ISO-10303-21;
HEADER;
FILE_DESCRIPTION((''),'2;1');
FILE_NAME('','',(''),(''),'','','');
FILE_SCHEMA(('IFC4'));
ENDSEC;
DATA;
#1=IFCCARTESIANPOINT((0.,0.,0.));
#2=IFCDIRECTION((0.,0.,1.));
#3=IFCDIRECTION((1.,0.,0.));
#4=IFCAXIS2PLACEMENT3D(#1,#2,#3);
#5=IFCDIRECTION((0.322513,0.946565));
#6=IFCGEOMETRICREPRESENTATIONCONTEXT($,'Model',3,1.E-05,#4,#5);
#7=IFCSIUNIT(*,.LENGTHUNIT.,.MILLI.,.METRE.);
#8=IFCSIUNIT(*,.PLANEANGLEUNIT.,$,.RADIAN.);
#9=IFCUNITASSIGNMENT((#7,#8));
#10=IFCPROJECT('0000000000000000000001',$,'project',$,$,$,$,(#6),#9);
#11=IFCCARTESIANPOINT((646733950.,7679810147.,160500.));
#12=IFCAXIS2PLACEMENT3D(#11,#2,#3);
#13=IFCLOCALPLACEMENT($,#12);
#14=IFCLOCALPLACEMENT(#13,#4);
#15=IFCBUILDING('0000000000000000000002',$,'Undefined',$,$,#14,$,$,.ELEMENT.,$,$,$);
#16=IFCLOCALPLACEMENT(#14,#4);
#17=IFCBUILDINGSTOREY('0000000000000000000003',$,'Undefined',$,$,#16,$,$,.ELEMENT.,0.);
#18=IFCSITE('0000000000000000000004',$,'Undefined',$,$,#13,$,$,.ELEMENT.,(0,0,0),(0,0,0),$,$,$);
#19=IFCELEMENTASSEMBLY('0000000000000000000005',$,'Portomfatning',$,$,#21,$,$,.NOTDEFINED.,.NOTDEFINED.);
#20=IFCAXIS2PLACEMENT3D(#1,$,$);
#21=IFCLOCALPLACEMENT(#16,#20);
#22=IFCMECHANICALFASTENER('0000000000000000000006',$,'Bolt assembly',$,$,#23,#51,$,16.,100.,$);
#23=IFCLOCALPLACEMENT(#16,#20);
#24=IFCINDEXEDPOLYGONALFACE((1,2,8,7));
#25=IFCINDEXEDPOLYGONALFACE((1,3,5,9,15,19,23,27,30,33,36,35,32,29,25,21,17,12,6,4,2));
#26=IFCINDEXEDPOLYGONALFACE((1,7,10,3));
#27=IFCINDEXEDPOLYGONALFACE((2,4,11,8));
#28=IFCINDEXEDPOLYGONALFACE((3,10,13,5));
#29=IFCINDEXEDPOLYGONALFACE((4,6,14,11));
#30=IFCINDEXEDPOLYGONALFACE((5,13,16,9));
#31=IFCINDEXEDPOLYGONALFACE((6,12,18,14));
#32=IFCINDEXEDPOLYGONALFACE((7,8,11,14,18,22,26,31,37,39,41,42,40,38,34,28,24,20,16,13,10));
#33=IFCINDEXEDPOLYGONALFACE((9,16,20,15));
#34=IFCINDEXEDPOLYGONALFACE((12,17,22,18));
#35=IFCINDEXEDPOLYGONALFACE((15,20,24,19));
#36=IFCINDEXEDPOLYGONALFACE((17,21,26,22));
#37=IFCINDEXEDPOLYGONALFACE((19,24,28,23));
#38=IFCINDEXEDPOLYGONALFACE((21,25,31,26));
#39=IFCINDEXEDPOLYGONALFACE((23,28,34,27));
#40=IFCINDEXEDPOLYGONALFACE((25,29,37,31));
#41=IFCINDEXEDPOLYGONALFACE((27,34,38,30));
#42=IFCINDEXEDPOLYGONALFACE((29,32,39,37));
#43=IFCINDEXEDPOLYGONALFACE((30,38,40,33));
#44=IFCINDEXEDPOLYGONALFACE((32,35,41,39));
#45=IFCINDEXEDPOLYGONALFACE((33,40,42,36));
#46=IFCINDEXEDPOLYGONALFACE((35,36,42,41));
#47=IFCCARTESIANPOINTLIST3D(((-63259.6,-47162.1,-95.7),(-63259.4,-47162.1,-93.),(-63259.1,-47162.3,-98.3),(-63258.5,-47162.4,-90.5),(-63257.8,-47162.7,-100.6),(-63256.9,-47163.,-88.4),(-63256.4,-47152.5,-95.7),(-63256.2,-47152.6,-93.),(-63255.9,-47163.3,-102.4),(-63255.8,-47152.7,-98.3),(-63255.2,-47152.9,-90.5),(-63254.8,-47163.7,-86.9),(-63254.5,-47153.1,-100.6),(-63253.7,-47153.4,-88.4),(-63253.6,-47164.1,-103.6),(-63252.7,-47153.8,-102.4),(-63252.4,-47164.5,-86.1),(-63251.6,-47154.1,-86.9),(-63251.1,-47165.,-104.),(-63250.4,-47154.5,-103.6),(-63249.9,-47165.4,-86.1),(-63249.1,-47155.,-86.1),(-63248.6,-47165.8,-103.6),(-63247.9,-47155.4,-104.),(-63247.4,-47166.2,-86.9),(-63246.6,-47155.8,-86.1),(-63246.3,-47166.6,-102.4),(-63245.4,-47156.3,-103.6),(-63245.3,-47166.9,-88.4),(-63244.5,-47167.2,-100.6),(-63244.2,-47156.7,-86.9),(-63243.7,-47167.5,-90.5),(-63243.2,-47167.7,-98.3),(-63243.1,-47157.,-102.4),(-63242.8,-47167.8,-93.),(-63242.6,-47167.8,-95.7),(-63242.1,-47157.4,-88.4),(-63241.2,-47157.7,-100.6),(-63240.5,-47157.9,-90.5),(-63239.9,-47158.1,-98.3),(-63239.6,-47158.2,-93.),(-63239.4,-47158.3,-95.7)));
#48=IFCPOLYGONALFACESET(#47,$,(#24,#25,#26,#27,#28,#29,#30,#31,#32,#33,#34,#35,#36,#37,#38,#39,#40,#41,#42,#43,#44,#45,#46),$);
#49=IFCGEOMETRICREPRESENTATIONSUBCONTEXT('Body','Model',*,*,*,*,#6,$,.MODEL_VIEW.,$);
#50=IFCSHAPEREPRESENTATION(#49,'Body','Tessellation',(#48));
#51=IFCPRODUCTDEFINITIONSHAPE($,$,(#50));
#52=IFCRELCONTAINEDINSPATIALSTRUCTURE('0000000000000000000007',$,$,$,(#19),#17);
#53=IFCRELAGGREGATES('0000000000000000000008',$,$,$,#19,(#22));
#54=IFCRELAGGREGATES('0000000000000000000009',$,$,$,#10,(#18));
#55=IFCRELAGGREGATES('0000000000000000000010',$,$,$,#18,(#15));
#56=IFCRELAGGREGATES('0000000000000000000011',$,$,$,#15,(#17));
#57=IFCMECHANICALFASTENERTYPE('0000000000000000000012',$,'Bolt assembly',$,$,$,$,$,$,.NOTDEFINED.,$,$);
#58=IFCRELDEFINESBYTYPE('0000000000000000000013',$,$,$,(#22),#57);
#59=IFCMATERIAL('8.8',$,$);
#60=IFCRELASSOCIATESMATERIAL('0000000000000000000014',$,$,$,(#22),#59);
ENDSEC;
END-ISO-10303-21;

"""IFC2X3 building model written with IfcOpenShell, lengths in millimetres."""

from ifc_helpers import new_model, si_unit, direction, frame, origin_with_axes, origin_2d_with_axis, place, context, subcontext, project, spatial, circle, extrude, source, transform, mapped, material, type_object, element, aggregate, save


model = new_model("IFC2X3")

# Units and contexts
model_context = context("Model", 3, precision=1e-05, world=origin_with_axes(), true_north=direction((0.322513, 0.946565)))
body_context = subcontext(model_context, "Body", "Model", "MODEL_VIEW")
ifc_project = project(units=[si_unit("LENGTHUNIT", "METRE", prefix="MILLI"), si_unit("PLANEANGLEUNIT", "RADIAN")], contexts=[model_context])

# Site, building, storey
site_placement = place(None, frame((646733950.0, 7679810147.0, 160500.0), z_axis=(0.0, 0.0, 1.0), x_axis=(1.0, 0.0, 0.0)))
site = spatial("IfcSite", under=ifc_project, at=site_placement, Name="Undefined", CompositionType="ELEMENT", RefLatitude=(0, 0, 0), RefLongitude=(0, 0, 0))
building_placement = place(site_placement, origin_with_axes())
building = spatial("IfcBuilding", under=site, at=building_placement, Name="Undefined", CompositionType="ELEMENT")
storey_placement = place(building_placement, origin_with_axes())
storey = spatial("IfcBuildingStorey", under=building, at=storey_placement, Name="Undefined", CompositionType="ELEMENT", Elevation=0.0)

# Element assembly
assembly_1_placement = place(storey_placement, origin_with_axes())
assembly_1 = element("IfcElementAssembly", 1, at=assembly_1_placement, inside=storey, Name="Portomfatning", AssemblyPlace="NOTDEFINED", PredefinedType="NOTDEFINED")

# Mechanical fastener
ifc_material_1 = material(Name="8.8")
mechanical_fastener_type = type_object("IfcMechanicalFastenerType", Name="Bolt assembly")
shared_shape_1 = source(origin_with_axes(), body_context, "Body", "SweptSolid", [
    extrude(circle(Radius=9.0, at=origin_2d_with_axis()), frame((0.0, -10.0, 0.0), z_axis=(0.0, 1.0, 0.0), x_axis=(1.0, 0.0, 0.0)), (0.0, 0.0, 1.0), 10.1),
])
mechanical_fastener_1_placement = place(assembly_1_placement, frame((-63247.9, -47155.5, -95.0), z_axis=(0.946565, -0.322513, -0.000025), x_axis=(-0.000024, 0.000008, -1.0)))
mechanical_fastener_1 = element("IfcMechanicalFastener", 2, at=mechanical_fastener_1_placement, type_object=mechanical_fastener_type, material=ifc_material_1, Name="Bolt assembly", NominalDiameter=16.0, NominalLength=100.0, context=body_context, shape_type="MappedRepresentation", body=[
    mapped(shared_shape_1, transform((0.0, 0.0, 0.0))),
])
aggregate(assembly_1, [mechanical_fastener_1])

save(model, "model.ifc")
